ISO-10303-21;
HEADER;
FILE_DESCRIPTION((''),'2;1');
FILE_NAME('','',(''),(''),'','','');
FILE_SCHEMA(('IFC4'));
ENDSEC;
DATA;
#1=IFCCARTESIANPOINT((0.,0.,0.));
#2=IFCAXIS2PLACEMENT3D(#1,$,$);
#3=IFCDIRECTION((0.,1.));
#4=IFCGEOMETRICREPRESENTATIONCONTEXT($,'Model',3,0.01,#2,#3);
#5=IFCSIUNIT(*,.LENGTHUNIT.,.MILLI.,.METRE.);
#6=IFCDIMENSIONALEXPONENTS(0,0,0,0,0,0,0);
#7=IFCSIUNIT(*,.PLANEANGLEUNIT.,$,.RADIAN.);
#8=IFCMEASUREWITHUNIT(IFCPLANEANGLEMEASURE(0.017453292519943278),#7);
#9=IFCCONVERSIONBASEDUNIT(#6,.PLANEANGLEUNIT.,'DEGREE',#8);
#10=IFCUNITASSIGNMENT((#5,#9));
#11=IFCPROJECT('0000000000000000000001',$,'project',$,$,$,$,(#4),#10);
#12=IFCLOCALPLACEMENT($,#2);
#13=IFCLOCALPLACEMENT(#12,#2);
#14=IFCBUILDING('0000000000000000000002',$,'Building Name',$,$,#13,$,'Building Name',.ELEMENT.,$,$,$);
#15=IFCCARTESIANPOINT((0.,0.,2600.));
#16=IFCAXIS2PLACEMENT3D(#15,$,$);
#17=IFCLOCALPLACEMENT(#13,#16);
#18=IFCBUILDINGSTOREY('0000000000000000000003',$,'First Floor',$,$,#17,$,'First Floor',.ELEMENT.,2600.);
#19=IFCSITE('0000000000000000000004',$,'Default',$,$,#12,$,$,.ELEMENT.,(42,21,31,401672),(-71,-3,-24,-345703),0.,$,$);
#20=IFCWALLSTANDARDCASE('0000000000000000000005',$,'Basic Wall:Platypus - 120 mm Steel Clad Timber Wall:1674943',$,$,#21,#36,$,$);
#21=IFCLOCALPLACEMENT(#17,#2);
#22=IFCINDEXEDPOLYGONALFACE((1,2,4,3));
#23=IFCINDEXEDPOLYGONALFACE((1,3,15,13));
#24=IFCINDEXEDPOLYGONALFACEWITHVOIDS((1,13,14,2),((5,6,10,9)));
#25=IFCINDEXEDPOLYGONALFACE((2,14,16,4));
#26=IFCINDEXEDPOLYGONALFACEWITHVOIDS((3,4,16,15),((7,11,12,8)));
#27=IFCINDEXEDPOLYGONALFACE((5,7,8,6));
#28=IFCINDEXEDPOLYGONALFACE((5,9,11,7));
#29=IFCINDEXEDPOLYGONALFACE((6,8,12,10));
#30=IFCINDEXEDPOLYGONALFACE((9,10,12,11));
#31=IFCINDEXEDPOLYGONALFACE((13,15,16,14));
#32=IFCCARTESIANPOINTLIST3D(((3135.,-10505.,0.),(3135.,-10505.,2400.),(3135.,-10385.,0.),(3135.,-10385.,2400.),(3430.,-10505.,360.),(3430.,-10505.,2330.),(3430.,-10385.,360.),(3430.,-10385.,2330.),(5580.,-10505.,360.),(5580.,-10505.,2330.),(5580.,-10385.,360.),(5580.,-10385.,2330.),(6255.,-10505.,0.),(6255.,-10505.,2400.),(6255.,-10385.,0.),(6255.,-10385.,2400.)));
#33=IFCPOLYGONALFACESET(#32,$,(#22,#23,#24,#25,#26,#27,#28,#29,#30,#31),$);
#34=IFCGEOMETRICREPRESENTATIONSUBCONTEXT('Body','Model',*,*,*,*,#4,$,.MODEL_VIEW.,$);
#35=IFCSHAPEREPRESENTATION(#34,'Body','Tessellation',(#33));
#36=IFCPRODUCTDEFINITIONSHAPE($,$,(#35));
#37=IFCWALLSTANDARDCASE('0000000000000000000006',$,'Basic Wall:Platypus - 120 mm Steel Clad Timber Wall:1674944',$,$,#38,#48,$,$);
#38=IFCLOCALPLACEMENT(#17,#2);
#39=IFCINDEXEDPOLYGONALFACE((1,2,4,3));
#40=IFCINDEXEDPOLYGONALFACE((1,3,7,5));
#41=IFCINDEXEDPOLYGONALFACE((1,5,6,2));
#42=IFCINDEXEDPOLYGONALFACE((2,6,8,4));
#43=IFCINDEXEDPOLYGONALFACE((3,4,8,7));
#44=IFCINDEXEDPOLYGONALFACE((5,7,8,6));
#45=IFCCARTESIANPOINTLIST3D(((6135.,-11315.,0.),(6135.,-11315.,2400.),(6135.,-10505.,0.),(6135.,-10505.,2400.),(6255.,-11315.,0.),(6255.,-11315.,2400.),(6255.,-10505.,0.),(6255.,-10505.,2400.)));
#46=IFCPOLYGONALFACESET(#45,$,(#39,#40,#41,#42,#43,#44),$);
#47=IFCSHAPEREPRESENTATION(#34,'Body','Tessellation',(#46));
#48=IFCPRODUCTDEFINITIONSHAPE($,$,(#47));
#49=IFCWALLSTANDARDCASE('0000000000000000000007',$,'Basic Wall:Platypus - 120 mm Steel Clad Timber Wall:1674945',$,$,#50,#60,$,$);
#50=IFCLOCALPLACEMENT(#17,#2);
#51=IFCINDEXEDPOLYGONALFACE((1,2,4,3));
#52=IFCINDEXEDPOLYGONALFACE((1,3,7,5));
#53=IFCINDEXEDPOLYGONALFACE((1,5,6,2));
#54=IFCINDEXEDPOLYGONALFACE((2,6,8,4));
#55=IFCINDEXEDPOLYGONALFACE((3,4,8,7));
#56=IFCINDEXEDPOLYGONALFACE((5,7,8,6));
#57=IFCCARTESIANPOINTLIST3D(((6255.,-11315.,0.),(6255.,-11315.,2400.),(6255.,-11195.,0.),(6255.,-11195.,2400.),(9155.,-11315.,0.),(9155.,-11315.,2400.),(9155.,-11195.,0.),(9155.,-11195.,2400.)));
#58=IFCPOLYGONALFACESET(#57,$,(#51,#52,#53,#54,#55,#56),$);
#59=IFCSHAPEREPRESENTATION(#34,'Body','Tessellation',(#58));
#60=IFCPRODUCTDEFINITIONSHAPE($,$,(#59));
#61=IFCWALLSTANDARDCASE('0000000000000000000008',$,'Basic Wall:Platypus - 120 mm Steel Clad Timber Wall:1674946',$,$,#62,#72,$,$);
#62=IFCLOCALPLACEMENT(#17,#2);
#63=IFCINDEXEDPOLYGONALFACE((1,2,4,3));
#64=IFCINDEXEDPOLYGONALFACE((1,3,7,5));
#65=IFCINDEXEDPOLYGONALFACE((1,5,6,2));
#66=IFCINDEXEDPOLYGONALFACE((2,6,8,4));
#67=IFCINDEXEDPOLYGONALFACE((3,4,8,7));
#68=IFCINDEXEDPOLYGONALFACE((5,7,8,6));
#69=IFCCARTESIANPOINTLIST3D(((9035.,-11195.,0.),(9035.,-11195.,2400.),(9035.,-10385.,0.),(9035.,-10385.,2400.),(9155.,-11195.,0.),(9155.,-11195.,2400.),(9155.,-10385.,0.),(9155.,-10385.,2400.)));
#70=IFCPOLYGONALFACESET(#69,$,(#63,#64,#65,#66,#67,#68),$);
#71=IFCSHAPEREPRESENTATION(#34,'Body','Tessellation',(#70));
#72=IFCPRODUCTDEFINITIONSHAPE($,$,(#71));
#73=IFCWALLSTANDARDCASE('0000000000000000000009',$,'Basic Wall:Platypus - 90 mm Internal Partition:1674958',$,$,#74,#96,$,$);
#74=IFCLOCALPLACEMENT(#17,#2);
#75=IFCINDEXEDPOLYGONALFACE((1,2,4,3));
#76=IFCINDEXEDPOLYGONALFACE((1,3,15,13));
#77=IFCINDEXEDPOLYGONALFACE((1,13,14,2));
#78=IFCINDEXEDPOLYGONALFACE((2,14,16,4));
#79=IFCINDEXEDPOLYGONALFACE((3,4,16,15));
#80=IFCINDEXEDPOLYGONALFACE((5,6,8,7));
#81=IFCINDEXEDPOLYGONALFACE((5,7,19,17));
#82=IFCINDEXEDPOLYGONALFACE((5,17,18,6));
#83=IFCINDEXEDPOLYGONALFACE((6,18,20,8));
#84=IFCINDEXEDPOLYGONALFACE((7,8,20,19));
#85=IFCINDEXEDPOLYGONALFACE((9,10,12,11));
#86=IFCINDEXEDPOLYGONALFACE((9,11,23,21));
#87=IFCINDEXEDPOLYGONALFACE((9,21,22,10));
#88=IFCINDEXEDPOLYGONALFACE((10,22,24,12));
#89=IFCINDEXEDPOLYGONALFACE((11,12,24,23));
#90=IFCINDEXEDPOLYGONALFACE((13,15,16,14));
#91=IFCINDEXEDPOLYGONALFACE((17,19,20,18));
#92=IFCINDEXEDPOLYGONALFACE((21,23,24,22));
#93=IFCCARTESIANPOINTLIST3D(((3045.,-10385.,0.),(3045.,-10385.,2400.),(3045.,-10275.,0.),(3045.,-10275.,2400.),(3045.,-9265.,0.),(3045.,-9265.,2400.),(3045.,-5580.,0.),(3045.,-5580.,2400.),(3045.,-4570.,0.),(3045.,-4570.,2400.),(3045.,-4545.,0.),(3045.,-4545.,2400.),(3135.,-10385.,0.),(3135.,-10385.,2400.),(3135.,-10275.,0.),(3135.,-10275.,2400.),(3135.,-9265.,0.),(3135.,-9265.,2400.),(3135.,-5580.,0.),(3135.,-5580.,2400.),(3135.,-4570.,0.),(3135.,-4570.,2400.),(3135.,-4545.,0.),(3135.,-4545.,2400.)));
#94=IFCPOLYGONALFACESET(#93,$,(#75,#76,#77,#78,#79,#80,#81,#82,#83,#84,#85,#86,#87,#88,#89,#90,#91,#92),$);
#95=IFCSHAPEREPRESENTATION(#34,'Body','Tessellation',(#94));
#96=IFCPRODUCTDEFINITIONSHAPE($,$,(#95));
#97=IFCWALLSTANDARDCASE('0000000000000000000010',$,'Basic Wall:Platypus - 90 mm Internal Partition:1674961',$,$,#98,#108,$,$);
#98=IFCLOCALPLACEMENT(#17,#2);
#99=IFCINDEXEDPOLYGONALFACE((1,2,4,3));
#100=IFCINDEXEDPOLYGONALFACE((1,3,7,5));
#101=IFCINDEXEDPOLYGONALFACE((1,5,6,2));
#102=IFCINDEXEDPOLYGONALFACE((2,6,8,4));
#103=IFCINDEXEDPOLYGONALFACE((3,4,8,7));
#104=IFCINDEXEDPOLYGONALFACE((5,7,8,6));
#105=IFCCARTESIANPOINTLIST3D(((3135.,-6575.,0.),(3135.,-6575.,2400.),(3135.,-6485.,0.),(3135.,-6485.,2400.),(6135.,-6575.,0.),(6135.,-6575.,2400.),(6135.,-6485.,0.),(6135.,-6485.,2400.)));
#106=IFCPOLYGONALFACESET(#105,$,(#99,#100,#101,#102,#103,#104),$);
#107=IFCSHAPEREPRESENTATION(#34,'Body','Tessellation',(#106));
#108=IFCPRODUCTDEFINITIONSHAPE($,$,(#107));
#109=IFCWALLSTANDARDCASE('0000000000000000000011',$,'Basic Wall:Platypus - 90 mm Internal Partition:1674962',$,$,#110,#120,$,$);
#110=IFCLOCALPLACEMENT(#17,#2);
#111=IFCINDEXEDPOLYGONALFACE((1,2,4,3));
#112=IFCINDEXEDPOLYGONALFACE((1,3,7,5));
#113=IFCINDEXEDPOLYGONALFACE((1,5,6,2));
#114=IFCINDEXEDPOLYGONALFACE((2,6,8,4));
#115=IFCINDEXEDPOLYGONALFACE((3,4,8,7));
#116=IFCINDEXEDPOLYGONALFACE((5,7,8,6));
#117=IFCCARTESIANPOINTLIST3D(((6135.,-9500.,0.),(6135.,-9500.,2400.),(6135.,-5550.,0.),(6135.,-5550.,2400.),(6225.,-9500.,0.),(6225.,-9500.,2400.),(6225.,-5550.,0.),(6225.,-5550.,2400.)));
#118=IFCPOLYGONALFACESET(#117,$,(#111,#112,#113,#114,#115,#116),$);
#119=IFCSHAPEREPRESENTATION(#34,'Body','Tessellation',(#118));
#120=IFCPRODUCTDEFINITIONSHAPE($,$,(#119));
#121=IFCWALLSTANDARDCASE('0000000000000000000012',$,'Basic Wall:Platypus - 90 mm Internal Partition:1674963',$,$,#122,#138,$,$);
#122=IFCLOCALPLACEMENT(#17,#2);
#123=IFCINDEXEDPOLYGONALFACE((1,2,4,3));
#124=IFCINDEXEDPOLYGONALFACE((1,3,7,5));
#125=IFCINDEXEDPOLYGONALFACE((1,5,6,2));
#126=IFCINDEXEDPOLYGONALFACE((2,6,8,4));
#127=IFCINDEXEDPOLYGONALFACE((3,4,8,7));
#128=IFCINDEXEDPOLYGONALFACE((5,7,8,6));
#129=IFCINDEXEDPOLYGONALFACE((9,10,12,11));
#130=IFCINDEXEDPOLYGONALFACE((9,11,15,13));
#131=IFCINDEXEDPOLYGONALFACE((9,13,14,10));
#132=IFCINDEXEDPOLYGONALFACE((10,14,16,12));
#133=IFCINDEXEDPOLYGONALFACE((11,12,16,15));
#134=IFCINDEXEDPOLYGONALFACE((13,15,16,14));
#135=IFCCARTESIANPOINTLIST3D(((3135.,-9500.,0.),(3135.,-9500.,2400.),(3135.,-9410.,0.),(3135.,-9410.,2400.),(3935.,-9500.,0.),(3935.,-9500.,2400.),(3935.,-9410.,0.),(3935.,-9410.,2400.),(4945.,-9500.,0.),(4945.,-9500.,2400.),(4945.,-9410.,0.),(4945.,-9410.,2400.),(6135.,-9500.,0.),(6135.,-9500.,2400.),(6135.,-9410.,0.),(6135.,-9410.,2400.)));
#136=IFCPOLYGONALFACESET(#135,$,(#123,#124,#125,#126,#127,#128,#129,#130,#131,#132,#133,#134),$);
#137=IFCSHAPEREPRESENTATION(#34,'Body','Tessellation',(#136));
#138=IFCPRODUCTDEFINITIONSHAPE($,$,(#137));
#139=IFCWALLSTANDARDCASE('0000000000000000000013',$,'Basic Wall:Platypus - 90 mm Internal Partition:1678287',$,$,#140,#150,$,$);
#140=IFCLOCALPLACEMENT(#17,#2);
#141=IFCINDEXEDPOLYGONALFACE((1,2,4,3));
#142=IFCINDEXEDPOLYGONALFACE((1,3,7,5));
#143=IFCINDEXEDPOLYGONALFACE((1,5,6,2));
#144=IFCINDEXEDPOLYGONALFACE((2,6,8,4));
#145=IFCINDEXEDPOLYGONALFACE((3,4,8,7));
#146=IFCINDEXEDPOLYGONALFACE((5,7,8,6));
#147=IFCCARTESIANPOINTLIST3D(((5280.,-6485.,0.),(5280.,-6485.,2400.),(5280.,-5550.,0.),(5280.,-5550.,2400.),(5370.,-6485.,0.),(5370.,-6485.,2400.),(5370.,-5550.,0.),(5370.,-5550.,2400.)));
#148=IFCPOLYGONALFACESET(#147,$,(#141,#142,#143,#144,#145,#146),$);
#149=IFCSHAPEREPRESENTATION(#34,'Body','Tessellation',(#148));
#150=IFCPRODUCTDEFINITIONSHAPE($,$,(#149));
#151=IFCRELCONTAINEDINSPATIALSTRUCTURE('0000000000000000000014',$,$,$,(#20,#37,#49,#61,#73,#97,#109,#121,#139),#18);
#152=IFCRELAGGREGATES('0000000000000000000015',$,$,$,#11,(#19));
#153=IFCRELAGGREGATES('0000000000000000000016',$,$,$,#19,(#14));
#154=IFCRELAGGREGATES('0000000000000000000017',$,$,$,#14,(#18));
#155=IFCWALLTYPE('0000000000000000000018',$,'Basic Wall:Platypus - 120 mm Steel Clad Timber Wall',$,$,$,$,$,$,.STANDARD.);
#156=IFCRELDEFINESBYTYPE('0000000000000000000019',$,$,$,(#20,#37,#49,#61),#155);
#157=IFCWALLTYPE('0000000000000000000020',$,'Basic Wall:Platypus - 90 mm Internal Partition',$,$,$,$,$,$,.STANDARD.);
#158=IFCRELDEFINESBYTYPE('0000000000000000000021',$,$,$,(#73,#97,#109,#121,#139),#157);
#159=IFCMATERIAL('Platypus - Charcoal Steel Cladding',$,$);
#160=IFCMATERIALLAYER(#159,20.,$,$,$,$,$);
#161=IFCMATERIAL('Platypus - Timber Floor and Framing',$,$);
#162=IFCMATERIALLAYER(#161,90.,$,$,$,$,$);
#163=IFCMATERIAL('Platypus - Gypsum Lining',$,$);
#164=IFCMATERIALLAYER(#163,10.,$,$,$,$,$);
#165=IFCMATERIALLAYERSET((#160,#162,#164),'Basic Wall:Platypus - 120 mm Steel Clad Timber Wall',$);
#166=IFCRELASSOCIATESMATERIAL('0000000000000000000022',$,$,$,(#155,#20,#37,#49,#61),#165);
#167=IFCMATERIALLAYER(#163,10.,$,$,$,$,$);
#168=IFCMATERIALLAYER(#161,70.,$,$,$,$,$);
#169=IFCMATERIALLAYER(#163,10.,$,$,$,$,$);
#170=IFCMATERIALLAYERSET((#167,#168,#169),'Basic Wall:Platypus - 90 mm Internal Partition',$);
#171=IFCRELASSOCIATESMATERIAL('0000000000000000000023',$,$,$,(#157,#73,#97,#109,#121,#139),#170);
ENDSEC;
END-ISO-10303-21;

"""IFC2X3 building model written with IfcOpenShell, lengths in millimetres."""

from ifc_helpers import new_model, entity, si_unit, converted_unit, direction, frame, frame_2d, origin, place, context, subcontext, project, spatial, rectangle, extrude, material, layer, layer_set, layer_usage, type_object, element, save


model = new_model("IFC2X3")

# Units and contexts
model_context = context("Model", 3, precision=0.01, world=origin(), true_north=direction((0.0, 1.0)))
body_context = subcontext(model_context, "Body", "Model", "MODEL_VIEW")
ifc_project = project(units=[si_unit("LENGTHUNIT", "METRE", prefix="MILLI"), converted_unit("PLANEANGLEUNIT", "DEGREE", entity("IfcPlaneAngleMeasure", 0.017453292519943278), si_unit("PLANEANGLEUNIT", "RADIAN"), dimensions=[0, 0, 0, 0, 0, 0, 0])], contexts=[model_context])

# Site, building, storey
site_placement = place(None, origin())
site = spatial("IfcSite", under=ifc_project, at=site_placement, Name="Default", CompositionType="ELEMENT", RefLatitude=(42, 21, 31, 401672), RefLongitude=(-71, -3, -24, -345703), RefElevation=0.0)
building_placement = place(site_placement, origin())
building = spatial("IfcBuilding", under=site, at=building_placement, Name="Building Name", LongName="Building Name", CompositionType="ELEMENT")
storey_placement = place(building_placement, frame((0.0, 0.0, 2600.0)))
storey = spatial("IfcBuildingStorey", under=building, at=storey_placement, Name="First Floor", LongName="First Floor", CompositionType="ELEMENT", Elevation=2600.0)

# Shared definitions
ifc_material_1 = material(Name="Platypus - Timber Floor and Framing")
ifc_material_2 = material(Name="Platypus - Gypsum Lining")

# Shared definitions
ifc_material_3 = material(Name="Platypus - Charcoal Steel Cladding")
ifc_layer_1 = layer(ifc_material_3, 20.0)
ifc_layer_2 = layer(ifc_material_1, 90.0)
ifc_layer_3 = layer(ifc_material_2, 10.0)
ifc_layer_set_1 = layer_set([ifc_layer_1, ifc_layer_2, ifc_layer_3], Name="Basic Wall:Platypus - 120 mm Steel Clad Timber Wall")
wall_type_1 = type_object("IfcWallType", Name="Basic Wall:Platypus - 120 mm Steel Clad Timber Wall", PredefinedType="STANDARD", material=ifc_layer_set_1)

# Wall, opening
ifc_layer_usage_1 = layer_usage(ifc_layer_set_1, "AXIS2", "POSITIVE", -60.0)
wall_1_placement = place(storey_placement, frame((3135.0, -10445.0, 0.0)))
wall_1 = element("IfcWallStandardCase", 1, at=wall_1_placement, inside=storey, type_object=wall_type_1, material=ifc_layer_usage_1, Name="Basic Wall:Platypus - 120 mm Steel Clad Timber Wall:1674943", context=body_context, shape_type="SweptSolid", body=[
    extrude(rectangle(XDim=3120.0, YDim=120.0, at=frame_2d((1560.0, 0.0), x_axis=(-1.0, 0.0))), origin(), (0.0, 0.0, 1.0), 2400.0),
])
opening_1_placement = place(wall_1_placement, frame((295.0, -60.0, 360.0)))
element("IfcOpeningElement", 2, at=opening_1_placement, cuts=wall_1, ObjectType="Opening", context=body_context, shape_type="SweptSolid", body=[
    extrude(rectangle(XDim=1970.0, YDim=2150.0, at=frame_2d((985.0, 1075.0), x_axis=(-1.0, 0.0))), frame((0.0, 0.0, 0.0), z_axis=(0.0, 1.0, 0.0), x_axis=(0.0, 0.0, 1.0)), (0.0, 0.0, 1.0), 120.0),
])

# Walls
ifc_layer_usage_2 = layer_usage(ifc_layer_set_1, "AXIS2", "POSITIVE", -60.0)
wall_2_placement = place(storey_placement, frame((6195.0, -10505.0, 0.0), z_axis=(0.0, 0.0, 1.0), x_axis=(0.0, -1.0, 0.0)))
element("IfcWallStandardCase", 3, at=wall_2_placement, inside=storey, type_object=wall_type_1, material=ifc_layer_usage_2, Name="Basic Wall:Platypus - 120 mm Steel Clad Timber Wall:1674944", context=body_context, shape_type="SweptSolid", body=[
    extrude(rectangle(XDim=810.0, YDim=120.0, at=frame_2d((405.0, 0.0), x_axis=(-1.0, 0.0))), origin(), (0.0, 0.0, 1.0), 2400.0),
])
ifc_layer_usage_3 = layer_usage(ifc_layer_set_1, "AXIS2", "POSITIVE", -60.0)
wall_3_placement = place(storey_placement, frame((6255.0, -11255.0, 0.0)))
element("IfcWallStandardCase", 4, at=wall_3_placement, inside=storey, type_object=wall_type_1, material=ifc_layer_usage_3, Name="Basic Wall:Platypus - 120 mm Steel Clad Timber Wall:1674945", context=body_context, shape_type="SweptSolid", body=[
    extrude(rectangle(XDim=2900.0, YDim=120.0, at=frame_2d((1450.0, 0.0), x_axis=(-1.0, 0.0))), origin(), (0.0, 0.0, 1.0), 2400.0),
])
ifc_layer_usage_4 = layer_usage(ifc_layer_set_1, "AXIS2", "POSITIVE", -60.0)
wall_4_placement = place(storey_placement, frame((9095.0, -11195.0, 0.0), z_axis=(0.0, 0.0, 1.0), x_axis=(0.0, 1.0, 0.0)))
element("IfcWallStandardCase", 5, at=wall_4_placement, inside=storey, type_object=wall_type_1, material=ifc_layer_usage_4, Name="Basic Wall:Platypus - 120 mm Steel Clad Timber Wall:1674946", context=body_context, shape_type="SweptSolid", body=[
    extrude(rectangle(XDim=810.0, YDim=120.0, at=frame_2d((405.0, 0.0), x_axis=(-1.0, 0.0))), origin(), (0.0, 0.0, 1.0), 2400.0),
])

# Wall, openings
ifc_layer_4 = layer(ifc_material_2, 10.0)
ifc_layer_5 = layer(ifc_material_1, 70.0)
ifc_layer_6 = layer(ifc_material_2, 10.0)
ifc_layer_set_2 = layer_set([ifc_layer_4, ifc_layer_5, ifc_layer_6], Name="Basic Wall:Platypus - 90 mm Internal Partition")
ifc_layer_usage_5 = layer_usage(ifc_layer_set_2, "AXIS2", "NEGATIVE", 45.0)
wall_type_2 = type_object("IfcWallType", Name="Basic Wall:Platypus - 90 mm Internal Partition", PredefinedType="STANDARD", material=ifc_layer_set_2)
wall_5_placement = place(storey_placement, frame((3090.0, -4545.0, 0.0), z_axis=(0.0, 0.0, 1.0), x_axis=(0.0, -1.0, 0.0)))
wall_5 = element("IfcWallStandardCase", 6, at=wall_5_placement, inside=storey, type_object=wall_type_2, material=ifc_layer_usage_5, Name="Basic Wall:Platypus - 90 mm Internal Partition:1674958", context=body_context, shape_type="SweptSolid", body=[
    extrude(rectangle(XDim=5840.0, YDim=90.0, at=frame_2d((2920.0, 0.0), x_axis=(-1.0, 0.0))), origin(), (0.0, 0.0, 1.0), 2400.0),
])
opening_2_placement = place(wall_5_placement, frame((4720.0, -45.0, 0.0)))
element("IfcOpeningElement", 7, at=opening_2_placement, cuts=wall_5, ObjectType="Opening", context=body_context, shape_type="SweptSolid", body=[
    extrude(rectangle(XDim=2440.0, YDim=1010.0, at=frame_2d((1220.0, 505.0), x_axis=(1.0, 0.0))), frame((0.0, 0.0, 0.0), z_axis=(0.0, 1.0, 0.0), x_axis=(0.0, 0.0, 1.0)), (0.0, 0.0, 1.0), 90.0),
])
opening_3_placement = place(wall_5_placement, frame((25.0, -45.0, 0.0)))
element("IfcOpeningElement", 8, at=opening_3_placement, cuts=wall_5, ObjectType="Opening", context=body_context, shape_type="SweptSolid", body=[
    extrude(rectangle(XDim=2440.0, YDim=1010.0, at=frame_2d((1220.0, 505.0), x_axis=(1.0, 0.0))), frame((0.0, 0.0, 0.0), z_axis=(0.0, 1.0, 0.0), x_axis=(0.0, 0.0, 1.0)), (0.0, 0.0, 1.0), 90.0),
])

# Walls
ifc_layer_usage_6 = layer_usage(ifc_layer_set_2, "AXIS2", "NEGATIVE", 45.0)
wall_6_placement = place(storey_placement, frame((3135.0, -6530.0, 0.0)))
element("IfcWallStandardCase", 9, at=wall_6_placement, inside=storey, type_object=wall_type_2, material=ifc_layer_usage_6, Name="Basic Wall:Platypus - 90 mm Internal Partition:1674961", context=body_context, shape_type="SweptSolid", body=[
    extrude(rectangle(XDim=3000.0, YDim=90.0, at=frame_2d((1500.0, 0.0), x_axis=(-1.0, 0.0))), origin(), (0.0, 0.0, 1.0), 2400.0),
])
ifc_layer_usage_7 = layer_usage(ifc_layer_set_2, "AXIS2", "NEGATIVE", 45.0)
wall_7_placement = place(storey_placement, frame((6180.0, -5550.0, 0.0), z_axis=(0.0, 0.0, 1.0), x_axis=(0.0, -1.0, 0.0)))
element("IfcWallStandardCase", 10, at=wall_7_placement, inside=storey, type_object=wall_type_2, material=ifc_layer_usage_7, Name="Basic Wall:Platypus - 90 mm Internal Partition:1674962", context=body_context, shape_type="SweptSolid", body=[
    extrude(rectangle(XDim=3950.0, YDim=90.0, at=frame_2d((1975.0, 0.0), x_axis=(-1.0, 0.0))), origin(), (0.0, 0.0, 1.0), 2400.0),
])

# Wall, opening
ifc_layer_usage_8 = layer_usage(ifc_layer_set_2, "AXIS2", "NEGATIVE", 45.0)
wall_8_placement = place(storey_placement, frame((3135.0, -9455.0, 0.0)))
wall_8 = element("IfcWallStandardCase", 11, at=wall_8_placement, inside=storey, type_object=wall_type_2, material=ifc_layer_usage_8, Name="Basic Wall:Platypus - 90 mm Internal Partition:1674963", context=body_context, shape_type="SweptSolid", body=[
    extrude(rectangle(XDim=90.0, YDim=3000.0, at=frame_2d((1500.0, 0.0), x_axis=(0.0, -1.0))), origin(), (0.0, 0.0, 1.0), 2400.0),
])
opening_4_placement = place(wall_8_placement, frame((800.0, -45.0, 0.0)))
element("IfcOpeningElement", 12, at=opening_4_placement, cuts=wall_8, ObjectType="Opening", context=body_context, shape_type="SweptSolid", body=[
    extrude(rectangle(XDim=2440.0, YDim=1010.0, at=frame_2d((1220.0, 505.0), x_axis=(1.0, 0.0))), frame((0.0, 0.0, 0.0), z_axis=(0.0, 1.0, 0.0), x_axis=(0.0, 0.0, 1.0)), (0.0, 0.0, 1.0), 90.0),
])

# Wall
ifc_layer_usage_9 = layer_usage(ifc_layer_set_2, "AXIS2", "NEGATIVE", 45.0)
wall_9_placement = place(storey_placement, frame((5325.0, -6485.0, 0.0), z_axis=(0.0, 0.0, 1.0), x_axis=(0.0, 1.0, 0.0)))
element("IfcWallStandardCase", 13, at=wall_9_placement, inside=storey, type_object=wall_type_2, material=ifc_layer_usage_9, Name="Basic Wall:Platypus - 90 mm Internal Partition:1678287", context=body_context, shape_type="SweptSolid", body=[
    extrude(rectangle(XDim=935.0, YDim=90.0, at=frame_2d((467.5, 0.0), x_axis=(-1.0, 0.0))), origin(), (0.0, 0.0, 1.0), 2400.0),
])

save(model, "model.ifc")
